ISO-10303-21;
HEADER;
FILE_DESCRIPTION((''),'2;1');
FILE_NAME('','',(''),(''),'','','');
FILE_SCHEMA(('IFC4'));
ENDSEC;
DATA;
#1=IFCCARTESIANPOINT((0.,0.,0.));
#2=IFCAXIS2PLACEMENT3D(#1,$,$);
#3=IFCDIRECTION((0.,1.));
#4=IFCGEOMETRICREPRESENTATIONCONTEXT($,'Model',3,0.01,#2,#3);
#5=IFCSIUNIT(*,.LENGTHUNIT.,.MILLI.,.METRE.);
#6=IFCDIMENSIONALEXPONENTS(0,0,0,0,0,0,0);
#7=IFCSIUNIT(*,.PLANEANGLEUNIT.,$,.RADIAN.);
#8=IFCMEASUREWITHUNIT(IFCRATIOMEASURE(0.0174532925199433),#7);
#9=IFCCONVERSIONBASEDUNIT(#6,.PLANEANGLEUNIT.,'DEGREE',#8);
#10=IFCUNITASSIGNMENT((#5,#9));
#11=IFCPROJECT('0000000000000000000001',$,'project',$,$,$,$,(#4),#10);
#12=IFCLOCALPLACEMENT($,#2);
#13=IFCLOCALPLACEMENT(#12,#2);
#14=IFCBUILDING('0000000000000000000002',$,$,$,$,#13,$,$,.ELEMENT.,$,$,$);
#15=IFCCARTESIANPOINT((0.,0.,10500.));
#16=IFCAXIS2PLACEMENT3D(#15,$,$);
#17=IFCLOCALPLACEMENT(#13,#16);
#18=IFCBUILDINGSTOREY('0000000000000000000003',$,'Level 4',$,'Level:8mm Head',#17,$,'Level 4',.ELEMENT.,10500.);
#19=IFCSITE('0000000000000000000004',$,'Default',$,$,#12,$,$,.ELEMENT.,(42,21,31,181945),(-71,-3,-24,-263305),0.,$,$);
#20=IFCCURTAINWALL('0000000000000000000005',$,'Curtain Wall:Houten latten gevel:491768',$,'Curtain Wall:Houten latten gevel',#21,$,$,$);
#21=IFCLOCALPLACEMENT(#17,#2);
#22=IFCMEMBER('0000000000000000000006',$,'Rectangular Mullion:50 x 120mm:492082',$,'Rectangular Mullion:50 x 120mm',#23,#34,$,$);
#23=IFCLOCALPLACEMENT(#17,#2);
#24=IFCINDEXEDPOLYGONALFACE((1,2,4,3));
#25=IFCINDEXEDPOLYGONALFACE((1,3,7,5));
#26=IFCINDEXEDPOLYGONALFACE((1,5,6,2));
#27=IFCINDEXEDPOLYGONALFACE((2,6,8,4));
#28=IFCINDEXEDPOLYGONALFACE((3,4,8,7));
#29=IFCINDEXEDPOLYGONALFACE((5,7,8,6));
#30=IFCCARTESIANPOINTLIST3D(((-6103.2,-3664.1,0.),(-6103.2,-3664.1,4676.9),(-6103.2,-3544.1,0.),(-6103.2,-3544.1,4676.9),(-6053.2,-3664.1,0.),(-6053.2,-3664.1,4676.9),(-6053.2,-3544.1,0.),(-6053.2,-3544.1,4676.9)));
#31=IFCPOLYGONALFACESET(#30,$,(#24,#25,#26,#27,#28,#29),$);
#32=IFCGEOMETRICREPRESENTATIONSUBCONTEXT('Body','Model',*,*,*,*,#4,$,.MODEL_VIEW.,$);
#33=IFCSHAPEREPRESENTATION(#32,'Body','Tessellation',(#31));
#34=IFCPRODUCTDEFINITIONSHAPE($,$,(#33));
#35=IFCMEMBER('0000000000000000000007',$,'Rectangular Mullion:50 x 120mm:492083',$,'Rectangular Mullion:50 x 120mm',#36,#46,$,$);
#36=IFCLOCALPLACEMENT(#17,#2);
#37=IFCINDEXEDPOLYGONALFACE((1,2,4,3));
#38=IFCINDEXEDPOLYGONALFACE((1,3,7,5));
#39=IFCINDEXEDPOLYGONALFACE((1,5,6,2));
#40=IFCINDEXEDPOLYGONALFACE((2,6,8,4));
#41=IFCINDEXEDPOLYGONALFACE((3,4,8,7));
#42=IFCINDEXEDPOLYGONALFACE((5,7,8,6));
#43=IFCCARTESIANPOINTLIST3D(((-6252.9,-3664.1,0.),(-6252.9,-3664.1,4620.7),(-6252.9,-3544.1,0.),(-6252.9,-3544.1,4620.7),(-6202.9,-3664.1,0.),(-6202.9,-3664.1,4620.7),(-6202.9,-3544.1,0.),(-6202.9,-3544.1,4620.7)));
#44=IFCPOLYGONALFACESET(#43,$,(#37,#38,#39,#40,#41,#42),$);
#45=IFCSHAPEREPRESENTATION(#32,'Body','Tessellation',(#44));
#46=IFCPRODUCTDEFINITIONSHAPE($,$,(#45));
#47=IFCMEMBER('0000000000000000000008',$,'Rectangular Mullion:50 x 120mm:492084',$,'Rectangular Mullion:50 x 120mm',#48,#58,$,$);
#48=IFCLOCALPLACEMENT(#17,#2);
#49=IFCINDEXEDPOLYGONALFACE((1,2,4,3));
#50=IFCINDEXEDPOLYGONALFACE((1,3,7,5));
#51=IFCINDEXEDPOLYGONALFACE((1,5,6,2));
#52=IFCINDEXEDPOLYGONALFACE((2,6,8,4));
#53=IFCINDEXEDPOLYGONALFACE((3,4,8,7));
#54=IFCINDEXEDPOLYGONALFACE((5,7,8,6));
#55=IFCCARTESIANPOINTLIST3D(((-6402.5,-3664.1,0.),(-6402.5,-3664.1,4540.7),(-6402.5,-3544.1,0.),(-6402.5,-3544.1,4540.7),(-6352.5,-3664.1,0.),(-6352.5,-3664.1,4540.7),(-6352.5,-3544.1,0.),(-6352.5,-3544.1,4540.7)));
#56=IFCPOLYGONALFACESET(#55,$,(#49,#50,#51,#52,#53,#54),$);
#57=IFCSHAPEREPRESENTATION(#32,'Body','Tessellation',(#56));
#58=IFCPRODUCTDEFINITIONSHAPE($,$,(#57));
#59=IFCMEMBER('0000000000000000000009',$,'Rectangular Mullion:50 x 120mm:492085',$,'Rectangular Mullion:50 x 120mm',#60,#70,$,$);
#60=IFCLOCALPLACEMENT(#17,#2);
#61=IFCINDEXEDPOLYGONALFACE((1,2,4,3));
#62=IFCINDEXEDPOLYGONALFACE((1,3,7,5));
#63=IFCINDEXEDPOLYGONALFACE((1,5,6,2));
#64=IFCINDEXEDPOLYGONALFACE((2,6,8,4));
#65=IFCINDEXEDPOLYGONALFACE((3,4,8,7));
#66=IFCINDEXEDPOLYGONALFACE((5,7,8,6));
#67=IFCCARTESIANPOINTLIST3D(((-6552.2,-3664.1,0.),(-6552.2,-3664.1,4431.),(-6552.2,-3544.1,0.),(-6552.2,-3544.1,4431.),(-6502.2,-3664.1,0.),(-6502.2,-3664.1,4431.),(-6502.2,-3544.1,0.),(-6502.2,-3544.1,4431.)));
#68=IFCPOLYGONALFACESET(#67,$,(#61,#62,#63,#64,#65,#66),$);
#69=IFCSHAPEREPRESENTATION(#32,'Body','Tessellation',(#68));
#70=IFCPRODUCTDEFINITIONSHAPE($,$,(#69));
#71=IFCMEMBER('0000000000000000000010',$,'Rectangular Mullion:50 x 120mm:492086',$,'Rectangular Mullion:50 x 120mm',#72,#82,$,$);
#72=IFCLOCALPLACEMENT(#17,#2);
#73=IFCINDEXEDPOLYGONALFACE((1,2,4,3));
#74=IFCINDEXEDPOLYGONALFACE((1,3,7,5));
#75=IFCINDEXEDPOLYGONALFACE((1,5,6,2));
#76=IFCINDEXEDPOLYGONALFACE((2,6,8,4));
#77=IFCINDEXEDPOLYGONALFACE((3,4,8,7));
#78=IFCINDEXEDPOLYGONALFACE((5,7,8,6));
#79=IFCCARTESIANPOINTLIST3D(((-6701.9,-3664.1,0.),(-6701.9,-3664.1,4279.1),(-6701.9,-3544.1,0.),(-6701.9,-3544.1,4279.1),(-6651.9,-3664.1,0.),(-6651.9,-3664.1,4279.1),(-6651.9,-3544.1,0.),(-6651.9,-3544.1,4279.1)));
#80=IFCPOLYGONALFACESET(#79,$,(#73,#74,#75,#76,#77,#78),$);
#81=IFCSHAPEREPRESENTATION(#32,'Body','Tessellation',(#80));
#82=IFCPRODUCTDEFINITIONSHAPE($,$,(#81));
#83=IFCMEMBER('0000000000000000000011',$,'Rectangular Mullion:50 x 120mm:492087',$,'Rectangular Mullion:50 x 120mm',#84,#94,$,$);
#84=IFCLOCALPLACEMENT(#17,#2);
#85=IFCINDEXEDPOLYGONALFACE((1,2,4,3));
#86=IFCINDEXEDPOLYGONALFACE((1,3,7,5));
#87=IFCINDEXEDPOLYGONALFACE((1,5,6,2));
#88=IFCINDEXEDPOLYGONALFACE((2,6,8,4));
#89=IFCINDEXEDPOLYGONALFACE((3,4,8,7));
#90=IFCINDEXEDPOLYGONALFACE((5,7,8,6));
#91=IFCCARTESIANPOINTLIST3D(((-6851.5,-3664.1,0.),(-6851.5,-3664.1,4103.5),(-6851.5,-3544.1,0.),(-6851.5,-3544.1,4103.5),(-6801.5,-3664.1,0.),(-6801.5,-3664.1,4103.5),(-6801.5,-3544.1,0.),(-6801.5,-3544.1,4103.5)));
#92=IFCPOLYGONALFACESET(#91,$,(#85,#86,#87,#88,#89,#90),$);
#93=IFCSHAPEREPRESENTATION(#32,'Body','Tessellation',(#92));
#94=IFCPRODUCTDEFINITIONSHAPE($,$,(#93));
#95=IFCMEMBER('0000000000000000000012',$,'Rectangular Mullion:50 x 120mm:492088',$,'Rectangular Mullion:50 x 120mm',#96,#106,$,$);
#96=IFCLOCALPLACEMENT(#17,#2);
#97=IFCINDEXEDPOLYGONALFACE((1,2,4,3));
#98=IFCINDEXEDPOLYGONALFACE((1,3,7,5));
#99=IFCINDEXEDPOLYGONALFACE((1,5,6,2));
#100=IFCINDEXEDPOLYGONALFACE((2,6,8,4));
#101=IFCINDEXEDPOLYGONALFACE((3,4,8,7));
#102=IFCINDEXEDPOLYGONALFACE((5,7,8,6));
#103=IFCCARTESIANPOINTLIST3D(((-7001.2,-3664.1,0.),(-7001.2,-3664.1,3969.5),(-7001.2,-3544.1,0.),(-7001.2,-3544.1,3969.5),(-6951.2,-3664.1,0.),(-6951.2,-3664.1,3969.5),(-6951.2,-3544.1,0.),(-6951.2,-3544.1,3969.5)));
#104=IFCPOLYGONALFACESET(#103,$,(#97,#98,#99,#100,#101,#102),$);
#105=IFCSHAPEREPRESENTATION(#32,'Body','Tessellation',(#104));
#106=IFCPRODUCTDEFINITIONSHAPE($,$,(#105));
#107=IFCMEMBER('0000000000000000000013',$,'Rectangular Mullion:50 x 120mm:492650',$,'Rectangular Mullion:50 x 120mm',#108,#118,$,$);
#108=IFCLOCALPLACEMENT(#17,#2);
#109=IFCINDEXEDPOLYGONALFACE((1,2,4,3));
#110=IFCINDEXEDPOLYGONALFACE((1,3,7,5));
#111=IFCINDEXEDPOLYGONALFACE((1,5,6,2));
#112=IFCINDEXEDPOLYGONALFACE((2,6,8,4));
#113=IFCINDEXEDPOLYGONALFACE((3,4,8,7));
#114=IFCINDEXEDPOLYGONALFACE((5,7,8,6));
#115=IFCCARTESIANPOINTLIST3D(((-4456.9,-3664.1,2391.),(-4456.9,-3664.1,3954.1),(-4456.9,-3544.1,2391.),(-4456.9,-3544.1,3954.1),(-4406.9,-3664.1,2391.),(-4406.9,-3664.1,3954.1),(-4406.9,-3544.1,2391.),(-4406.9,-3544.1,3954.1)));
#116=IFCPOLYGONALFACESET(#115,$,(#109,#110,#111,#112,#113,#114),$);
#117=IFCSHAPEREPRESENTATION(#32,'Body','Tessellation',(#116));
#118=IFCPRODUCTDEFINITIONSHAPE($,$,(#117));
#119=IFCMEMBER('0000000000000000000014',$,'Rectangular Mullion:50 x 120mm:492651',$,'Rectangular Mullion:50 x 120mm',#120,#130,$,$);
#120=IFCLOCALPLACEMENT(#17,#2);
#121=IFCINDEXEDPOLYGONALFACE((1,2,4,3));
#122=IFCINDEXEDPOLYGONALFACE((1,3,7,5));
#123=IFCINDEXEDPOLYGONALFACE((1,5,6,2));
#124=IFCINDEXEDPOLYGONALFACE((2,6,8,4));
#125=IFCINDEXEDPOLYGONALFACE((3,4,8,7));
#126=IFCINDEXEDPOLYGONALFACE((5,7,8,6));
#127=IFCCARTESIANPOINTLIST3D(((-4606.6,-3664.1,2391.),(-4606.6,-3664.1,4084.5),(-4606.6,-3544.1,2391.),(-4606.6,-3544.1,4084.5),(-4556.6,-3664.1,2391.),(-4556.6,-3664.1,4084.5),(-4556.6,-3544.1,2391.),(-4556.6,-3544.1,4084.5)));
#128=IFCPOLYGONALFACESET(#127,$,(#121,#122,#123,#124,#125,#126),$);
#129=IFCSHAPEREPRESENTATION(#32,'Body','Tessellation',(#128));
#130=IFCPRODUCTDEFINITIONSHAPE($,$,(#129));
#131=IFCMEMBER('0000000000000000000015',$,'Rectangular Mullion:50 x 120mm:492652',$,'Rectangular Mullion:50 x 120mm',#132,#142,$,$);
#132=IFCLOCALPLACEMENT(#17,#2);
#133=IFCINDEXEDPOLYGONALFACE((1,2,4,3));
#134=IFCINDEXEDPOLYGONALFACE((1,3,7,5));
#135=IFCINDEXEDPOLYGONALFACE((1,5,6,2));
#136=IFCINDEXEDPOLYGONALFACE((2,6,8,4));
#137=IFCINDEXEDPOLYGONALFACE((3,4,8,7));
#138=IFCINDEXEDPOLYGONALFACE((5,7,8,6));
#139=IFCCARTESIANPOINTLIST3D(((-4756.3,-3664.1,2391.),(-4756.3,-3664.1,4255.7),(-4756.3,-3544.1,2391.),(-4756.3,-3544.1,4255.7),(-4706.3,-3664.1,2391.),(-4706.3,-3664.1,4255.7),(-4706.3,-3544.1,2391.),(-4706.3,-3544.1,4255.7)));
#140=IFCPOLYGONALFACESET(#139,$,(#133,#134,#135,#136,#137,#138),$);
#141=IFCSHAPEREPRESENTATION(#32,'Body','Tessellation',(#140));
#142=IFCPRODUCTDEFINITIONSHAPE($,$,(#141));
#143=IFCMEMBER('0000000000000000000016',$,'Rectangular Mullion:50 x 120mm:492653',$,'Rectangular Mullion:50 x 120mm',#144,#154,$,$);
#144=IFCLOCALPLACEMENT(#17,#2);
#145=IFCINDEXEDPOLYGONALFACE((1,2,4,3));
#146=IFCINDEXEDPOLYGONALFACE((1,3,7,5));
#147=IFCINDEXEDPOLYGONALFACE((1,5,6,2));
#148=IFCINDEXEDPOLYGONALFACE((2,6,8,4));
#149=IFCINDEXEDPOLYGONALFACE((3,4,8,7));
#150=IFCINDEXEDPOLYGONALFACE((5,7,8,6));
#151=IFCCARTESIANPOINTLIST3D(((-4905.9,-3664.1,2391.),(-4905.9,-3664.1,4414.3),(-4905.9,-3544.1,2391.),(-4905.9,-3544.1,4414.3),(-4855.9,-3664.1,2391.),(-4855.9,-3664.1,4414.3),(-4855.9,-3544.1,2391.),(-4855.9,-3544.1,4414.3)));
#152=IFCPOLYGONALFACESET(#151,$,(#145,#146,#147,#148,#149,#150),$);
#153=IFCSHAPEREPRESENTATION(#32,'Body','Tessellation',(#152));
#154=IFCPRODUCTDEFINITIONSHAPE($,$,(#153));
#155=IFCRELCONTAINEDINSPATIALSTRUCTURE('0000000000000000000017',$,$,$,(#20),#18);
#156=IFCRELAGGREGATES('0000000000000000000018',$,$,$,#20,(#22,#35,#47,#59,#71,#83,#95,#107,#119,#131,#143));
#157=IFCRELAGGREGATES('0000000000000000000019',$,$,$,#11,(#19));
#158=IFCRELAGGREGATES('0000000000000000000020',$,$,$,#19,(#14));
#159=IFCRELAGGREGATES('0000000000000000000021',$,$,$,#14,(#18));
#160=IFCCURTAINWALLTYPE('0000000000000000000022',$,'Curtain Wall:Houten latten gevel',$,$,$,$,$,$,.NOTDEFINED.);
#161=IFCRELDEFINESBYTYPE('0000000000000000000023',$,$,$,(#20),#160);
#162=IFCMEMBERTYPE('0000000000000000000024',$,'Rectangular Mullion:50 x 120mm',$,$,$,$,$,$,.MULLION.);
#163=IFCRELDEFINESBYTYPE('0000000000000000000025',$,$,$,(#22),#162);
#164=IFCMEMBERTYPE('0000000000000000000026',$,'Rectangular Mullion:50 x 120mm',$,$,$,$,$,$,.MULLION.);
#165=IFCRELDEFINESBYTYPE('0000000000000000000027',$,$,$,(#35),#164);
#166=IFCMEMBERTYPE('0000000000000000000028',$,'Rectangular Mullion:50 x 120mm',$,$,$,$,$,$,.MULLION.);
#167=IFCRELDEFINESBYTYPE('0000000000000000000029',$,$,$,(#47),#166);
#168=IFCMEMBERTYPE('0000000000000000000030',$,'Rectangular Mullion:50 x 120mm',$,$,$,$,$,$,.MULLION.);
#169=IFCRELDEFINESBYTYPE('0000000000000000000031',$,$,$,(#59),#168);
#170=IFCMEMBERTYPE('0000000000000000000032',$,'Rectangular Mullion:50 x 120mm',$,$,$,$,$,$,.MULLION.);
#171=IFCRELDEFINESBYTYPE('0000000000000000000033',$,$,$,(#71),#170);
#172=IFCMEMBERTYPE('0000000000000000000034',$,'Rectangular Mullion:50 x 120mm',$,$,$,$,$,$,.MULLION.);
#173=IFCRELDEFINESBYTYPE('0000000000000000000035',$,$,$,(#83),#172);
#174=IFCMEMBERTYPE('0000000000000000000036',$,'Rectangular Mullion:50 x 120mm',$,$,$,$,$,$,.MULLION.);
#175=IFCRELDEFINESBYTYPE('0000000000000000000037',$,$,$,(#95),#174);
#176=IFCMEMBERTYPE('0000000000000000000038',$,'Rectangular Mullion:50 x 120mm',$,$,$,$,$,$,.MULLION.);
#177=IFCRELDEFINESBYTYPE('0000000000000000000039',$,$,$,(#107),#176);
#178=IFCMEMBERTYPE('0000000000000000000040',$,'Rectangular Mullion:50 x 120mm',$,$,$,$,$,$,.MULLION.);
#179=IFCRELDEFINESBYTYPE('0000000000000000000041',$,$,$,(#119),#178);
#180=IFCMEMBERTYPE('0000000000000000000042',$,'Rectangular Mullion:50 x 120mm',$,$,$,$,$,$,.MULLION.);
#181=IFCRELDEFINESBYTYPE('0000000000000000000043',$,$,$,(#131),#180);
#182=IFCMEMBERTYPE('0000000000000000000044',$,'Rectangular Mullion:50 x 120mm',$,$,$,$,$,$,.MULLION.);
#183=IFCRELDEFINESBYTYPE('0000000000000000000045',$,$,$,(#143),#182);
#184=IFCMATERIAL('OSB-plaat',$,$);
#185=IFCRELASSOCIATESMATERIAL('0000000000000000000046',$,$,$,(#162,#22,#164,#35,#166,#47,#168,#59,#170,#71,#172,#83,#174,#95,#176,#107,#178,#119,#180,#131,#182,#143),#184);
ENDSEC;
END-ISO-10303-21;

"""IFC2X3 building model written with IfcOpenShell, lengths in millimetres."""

from ifc_helpers import new_model, entity, si_unit, converted_unit, direction, frame, origin, origin_2d_with_axis, place, context, subcontext, project, spatial, rectangle, extrude, source, transform, mapped, material, type_object, type_shapes, element, aggregate, save


model = new_model("IFC2X3")

# Units and contexts
model_context = context("Model", 3, precision=0.01, world=origin(), true_north=direction((0.0, 1.0)))
body_context = subcontext(model_context, "Body", "Model", "MODEL_VIEW")
ifc_project = project(units=[si_unit("LENGTHUNIT", "METRE", prefix="MILLI"), converted_unit("PLANEANGLEUNIT", "DEGREE", entity("IfcRatioMeasure", 0.0174532925199433), si_unit("PLANEANGLEUNIT", "RADIAN"), dimensions=[0, 0, 0, 0, 0, 0, 0])], contexts=[model_context])

# Site, building, storey
site_placement = place(None, frame((0.0, 0.0, 0.0)))
site = spatial("IfcSite", under=ifc_project, at=site_placement, Name="Default", CompositionType="ELEMENT", RefLatitude=(42, 21, 31, 181945), RefLongitude=(-71, -3, -24, -263305), RefElevation=0.0)
building_placement = place(site_placement, origin())
building = spatial("IfcBuilding", under=site, at=building_placement, CompositionType="ELEMENT")
storey_placement = place(building_placement, frame((0.0, 0.0, 10500.0)))
storey = spatial("IfcBuildingStorey", under=building, at=storey_placement, Name="Level 4", ObjectType="Level:8mm Head", LongName="Level 4", CompositionType="ELEMENT", Elevation=10500.0)

# Curtain wall, members
curtain_wall_type = type_object("IfcCurtainWallType", Name="Curtain Wall:Houten latten gevel", PredefinedType="NOTDEFINED")
curtain_wall_placement = place(storey_placement, frame((0.0, 0.0, -10500.0)))
curtain_wall = element("IfcCurtainWall", 1, at=curtain_wall_placement, inside=storey, type_object=curtain_wall_type, Name="Curtain Wall:Houten latten gevel:491768", ObjectType="Curtain Wall:Houten latten gevel")
ifc_material_1 = material(Name="OSB-plaat")
placement = place(building_placement, frame((0.0, 0.0, 7500.0)))
member_type_1 = type_object("IfcMemberType", Name="Rectangular Mullion:50 x 120mm", PredefinedType="MULLION", material=ifc_material_1)
shared_shape_1 = source(origin(), body_context, "Body", "SweptSolid", [
    extrude(rectangle(XDim=120.0, YDim=50.0, at=origin_2d_with_axis()), frame((0.0, 0.0, -4676.9), z_axis=(0.0, 0.0, 1.0), x_axis=(0.0, -1.0, 0.0)), (0.0, 0.0, 1.0), 4676.9),
])
type_shapes(member_type_1, [shared_shape_1])
member_1_placement = place(placement, frame((-6078.2, -3604.1, 3000.0), z_axis=(0.0, 0.0, -1.0), x_axis=(-1.0, 0.0, 0.0)))
member_1 = element("IfcMember", 2, at=member_1_placement, type_object=member_type_1, material=ifc_material_1, Name="Rectangular Mullion:50 x 120mm:492082", ObjectType="Rectangular Mullion:50 x 120mm", context=body_context, shape_type="MappedRepresentation", body=[
    mapped(shared_shape_1, transform((0.0, 0.0, 0.0), scale=1.0)),
])
member_type_2 = type_object("IfcMemberType", Name="Rectangular Mullion:50 x 120mm", PredefinedType="MULLION", material=ifc_material_1)
shared_shape_2 = source(origin(), body_context, "Body", "SweptSolid", [
    extrude(rectangle(XDim=120.0, YDim=50.0, at=origin_2d_with_axis()), frame((0.0, 0.0, -4620.7), z_axis=(0.0, 0.0, 1.0), x_axis=(0.0, -1.0, 0.0)), (0.0, 0.0, 1.0), 4620.7),
])
type_shapes(member_type_2, [shared_shape_2])
member_2_placement = place(placement, frame((-6227.9, -3604.1, 3000.0), z_axis=(0.0, 0.0, -1.0), x_axis=(-1.0, 0.0, 0.0)))
member_2 = element("IfcMember", 3, at=member_2_placement, type_object=member_type_2, material=ifc_material_1, Name="Rectangular Mullion:50 x 120mm:492083", ObjectType="Rectangular Mullion:50 x 120mm", context=body_context, shape_type="MappedRepresentation", body=[
    mapped(shared_shape_2, transform((0.0, 0.0, 0.0), scale=1.0)),
])
member_type_3 = type_object("IfcMemberType", Name="Rectangular Mullion:50 x 120mm", PredefinedType="MULLION", material=ifc_material_1)
shared_shape_3 = source(origin(), body_context, "Body", "SweptSolid", [
    extrude(rectangle(XDim=120.0, YDim=50.0, at=origin_2d_with_axis()), frame((0.0, 0.0, -4540.7), z_axis=(0.0, 0.0, 1.0), x_axis=(0.0, -1.0, 0.0)), (0.0, 0.0, 1.0), 4540.7),
])
type_shapes(member_type_3, [shared_shape_3])
member_3_placement = place(placement, frame((-6377.5, -3604.1, 3000.0), z_axis=(0.0, 0.0, -1.0), x_axis=(-1.0, 0.0, 0.0)))
member_3 = element("IfcMember", 4, at=member_3_placement, type_object=member_type_3, material=ifc_material_1, Name="Rectangular Mullion:50 x 120mm:492084", ObjectType="Rectangular Mullion:50 x 120mm", context=body_context, shape_type="MappedRepresentation", body=[
    mapped(shared_shape_3, transform((0.0, 0.0, 0.0), scale=1.0)),
])
member_type_4 = type_object("IfcMemberType", Name="Rectangular Mullion:50 x 120mm", PredefinedType="MULLION", material=ifc_material_1)
shared_shape_4 = source(origin(), body_context, "Body", "SweptSolid", [
    extrude(rectangle(XDim=120.0, YDim=50.0, at=origin_2d_with_axis()), frame((0.0, 0.0, -4431.0), z_axis=(0.0, 0.0, 1.0), x_axis=(0.0, -1.0, 0.0)), (0.0, 0.0, 1.0), 4431.0),
])
type_shapes(member_type_4, [shared_shape_4])
member_4_placement = place(placement, frame((-6527.2, -3604.1, 3000.0), z_axis=(0.0, 0.0, -1.0), x_axis=(-1.0, 0.0, 0.0)))
member_4 = element("IfcMember", 5, at=member_4_placement, type_object=member_type_4, material=ifc_material_1, Name="Rectangular Mullion:50 x 120mm:492085", ObjectType="Rectangular Mullion:50 x 120mm", context=body_context, shape_type="MappedRepresentation", body=[
    mapped(shared_shape_4, transform((0.0, 0.0, 0.0), scale=1.0)),
])
member_type_5 = type_object("IfcMemberType", Name="Rectangular Mullion:50 x 120mm", PredefinedType="MULLION", material=ifc_material_1)
shared_shape_5 = source(origin(), body_context, "Body", "SweptSolid", [
    extrude(rectangle(XDim=120.0, YDim=50.0, at=origin_2d_with_axis()), frame((0.0, 0.0, -4279.1), z_axis=(0.0, 0.0, 1.0), x_axis=(0.0, -1.0, 0.0)), (0.0, 0.0, 1.0), 4279.1),
])
type_shapes(member_type_5, [shared_shape_5])
member_5_placement = place(placement, frame((-6676.9, -3604.1, 3000.0), z_axis=(0.0, 0.0, -1.0), x_axis=(-1.0, 0.0, 0.0)))
member_5 = element("IfcMember", 6, at=member_5_placement, type_object=member_type_5, material=ifc_material_1, Name="Rectangular Mullion:50 x 120mm:492086", ObjectType="Rectangular Mullion:50 x 120mm", context=body_context, shape_type="MappedRepresentation", body=[
    mapped(shared_shape_5, transform((0.0, 0.0, 0.0), scale=1.0)),
])
member_type_6 = type_object("IfcMemberType", Name="Rectangular Mullion:50 x 120mm", PredefinedType="MULLION", material=ifc_material_1)
shared_shape_6 = source(origin(), body_context, "Body", "SweptSolid", [
    extrude(rectangle(XDim=120.0, YDim=50.0, at=origin_2d_with_axis()), frame((0.0, 0.0, -4103.5), z_axis=(0.0, 0.0, 1.0), x_axis=(0.0, -1.0, 0.0)), (0.0, 0.0, 1.0), 4103.5),
])
type_shapes(member_type_6, [shared_shape_6])
member_6_placement = place(placement, frame((-6826.5, -3604.1, 3000.0), z_axis=(0.0, 0.0, -1.0), x_axis=(-1.0, 0.0, 0.0)))
member_6 = element("IfcMember", 7, at=member_6_placement, type_object=member_type_6, material=ifc_material_1, Name="Rectangular Mullion:50 x 120mm:492087", ObjectType="Rectangular Mullion:50 x 120mm", context=body_context, shape_type="MappedRepresentation", body=[
    mapped(shared_shape_6, transform((0.0, 0.0, 0.0), scale=1.0)),
])
member_type_7 = type_object("IfcMemberType", Name="Rectangular Mullion:50 x 120mm", PredefinedType="MULLION", material=ifc_material_1)
shared_shape_7 = source(origin(), body_context, "Body", "SweptSolid", [
    extrude(rectangle(XDim=120.0, YDim=50.0, at=origin_2d_with_axis()), frame((0.0, 0.0, -3969.5), z_axis=(0.0, 0.0, 1.0), x_axis=(0.0, -1.0, 0.0)), (0.0, 0.0, 1.0), 3969.5),
])
type_shapes(member_type_7, [shared_shape_7])
member_7_placement = place(placement, frame((-6976.2, -3604.1, 3000.0), z_axis=(0.0, 0.0, -1.0), x_axis=(-1.0, 0.0, 0.0)))
member_7 = element("IfcMember", 8, at=member_7_placement, type_object=member_type_7, material=ifc_material_1, Name="Rectangular Mullion:50 x 120mm:492088", ObjectType="Rectangular Mullion:50 x 120mm", context=body_context, shape_type="MappedRepresentation", body=[
    mapped(shared_shape_7, transform((0.0, 0.0, 0.0), scale=1.0)),
])
member_type_8 = type_object("IfcMemberType", Name="Rectangular Mullion:50 x 120mm", PredefinedType="MULLION", material=ifc_material_1)
shared_shape_8 = source(origin(), body_context, "Body", "SweptSolid", [
    extrude(rectangle(XDim=120.0, YDim=50.0, at=origin_2d_with_axis()), frame((0.0, 0.0, -1563.1), z_axis=(0.0, 0.0, 1.0), x_axis=(0.0, -1.0, 0.0)), (0.0, 0.0, 1.0), 1563.1),
])
type_shapes(member_type_8, [shared_shape_8])
member_8_placement = place(storey_placement, frame((-4431.9, -3604.1, 2391.0), z_axis=(0.0, 0.0, -1.0), x_axis=(-1.0, 0.0, 0.0)))
member_8 = element("IfcMember", 9, at=member_8_placement, type_object=member_type_8, material=ifc_material_1, Name="Rectangular Mullion:50 x 120mm:492650", ObjectType="Rectangular Mullion:50 x 120mm", context=body_context, shape_type="MappedRepresentation", body=[
    mapped(shared_shape_8, transform((0.0, 0.0, 0.0), scale=1.0)),
])
member_type_9 = type_object("IfcMemberType", Name="Rectangular Mullion:50 x 120mm", PredefinedType="MULLION", material=ifc_material_1)
shared_shape_9 = source(origin(), body_context, "Body", "SweptSolid", [
    extrude(rectangle(XDim=120.0, YDim=50.0, at=origin_2d_with_axis()), frame((0.0, 0.0, -1693.5), z_axis=(0.0, 0.0, 1.0), x_axis=(0.0, -1.0, 0.0)), (0.0, 0.0, 1.0), 1693.5),
])
type_shapes(member_type_9, [shared_shape_9])
member_9_placement = place(storey_placement, frame((-4581.6, -3604.1, 2391.0), z_axis=(0.0, 0.0, -1.0), x_axis=(-1.0, 0.0, 0.0)))
member_9 = element("IfcMember", 10, at=member_9_placement, type_object=member_type_9, material=ifc_material_1, Name="Rectangular Mullion:50 x 120mm:492651", ObjectType="Rectangular Mullion:50 x 120mm", context=body_context, shape_type="MappedRepresentation", body=[
    mapped(shared_shape_9, transform((0.0, 0.0, 0.0), scale=1.0)),
])
member_type_10 = type_object("IfcMemberType", Name="Rectangular Mullion:50 x 120mm", PredefinedType="MULLION", material=ifc_material_1)
shared_shape_10 = source(origin(), body_context, "Body", "SweptSolid", [
    extrude(rectangle(XDim=120.0, YDim=50.0, at=origin_2d_with_axis()), frame((0.0, 0.0, -1864.7), z_axis=(0.0, 0.0, 1.0), x_axis=(0.0, -1.0, 0.0)), (0.0, 0.0, 1.0), 1864.7),
])
type_shapes(member_type_10, [shared_shape_10])
member_10_placement = place(storey_placement, frame((-4731.3, -3604.1, 2391.0), z_axis=(0.0, 0.0, -1.0), x_axis=(-1.0, 0.0, 0.0)))
member_10 = element("IfcMember", 11, at=member_10_placement, type_object=member_type_10, material=ifc_material_1, Name="Rectangular Mullion:50 x 120mm:492652", ObjectType="Rectangular Mullion:50 x 120mm", context=body_context, shape_type="MappedRepresentation", body=[
    mapped(shared_shape_10, transform((0.0, 0.0, 0.0), scale=1.0)),
])
member_type_11 = type_object("IfcMemberType", Name="Rectangular Mullion:50 x 120mm", PredefinedType="MULLION", material=ifc_material_1)
shared_shape_11 = source(origin(), body_context, "Body", "SweptSolid", [
    extrude(rectangle(XDim=120.0, YDim=50.0, at=origin_2d_with_axis()), frame((0.0, 0.0, -2023.3), z_axis=(0.0, 0.0, 1.0), x_axis=(0.0, -1.0, 0.0)), (0.0, 0.0, 1.0), 2023.3),
])
type_shapes(member_type_11, [shared_shape_11])
member_11_placement = place(storey_placement, frame((-4880.9, -3604.1, 2391.0), z_axis=(0.0, 0.0, -1.0), x_axis=(-1.0, 0.0, 0.0)))
member_11 = element("IfcMember", 12, at=member_11_placement, type_object=member_type_11, material=ifc_material_1, Name="Rectangular Mullion:50 x 120mm:492653", ObjectType="Rectangular Mullion:50 x 120mm", context=body_context, shape_type="MappedRepresentation", body=[
    mapped(shared_shape_11, transform((0.0, 0.0, 0.0), scale=1.0)),
])
aggregate(curtain_wall, [member_1, member_2, member_3, member_4, member_5, member_6, member_7, member_8, member_9, member_10, member_11])

save(model, "model.ifc")
